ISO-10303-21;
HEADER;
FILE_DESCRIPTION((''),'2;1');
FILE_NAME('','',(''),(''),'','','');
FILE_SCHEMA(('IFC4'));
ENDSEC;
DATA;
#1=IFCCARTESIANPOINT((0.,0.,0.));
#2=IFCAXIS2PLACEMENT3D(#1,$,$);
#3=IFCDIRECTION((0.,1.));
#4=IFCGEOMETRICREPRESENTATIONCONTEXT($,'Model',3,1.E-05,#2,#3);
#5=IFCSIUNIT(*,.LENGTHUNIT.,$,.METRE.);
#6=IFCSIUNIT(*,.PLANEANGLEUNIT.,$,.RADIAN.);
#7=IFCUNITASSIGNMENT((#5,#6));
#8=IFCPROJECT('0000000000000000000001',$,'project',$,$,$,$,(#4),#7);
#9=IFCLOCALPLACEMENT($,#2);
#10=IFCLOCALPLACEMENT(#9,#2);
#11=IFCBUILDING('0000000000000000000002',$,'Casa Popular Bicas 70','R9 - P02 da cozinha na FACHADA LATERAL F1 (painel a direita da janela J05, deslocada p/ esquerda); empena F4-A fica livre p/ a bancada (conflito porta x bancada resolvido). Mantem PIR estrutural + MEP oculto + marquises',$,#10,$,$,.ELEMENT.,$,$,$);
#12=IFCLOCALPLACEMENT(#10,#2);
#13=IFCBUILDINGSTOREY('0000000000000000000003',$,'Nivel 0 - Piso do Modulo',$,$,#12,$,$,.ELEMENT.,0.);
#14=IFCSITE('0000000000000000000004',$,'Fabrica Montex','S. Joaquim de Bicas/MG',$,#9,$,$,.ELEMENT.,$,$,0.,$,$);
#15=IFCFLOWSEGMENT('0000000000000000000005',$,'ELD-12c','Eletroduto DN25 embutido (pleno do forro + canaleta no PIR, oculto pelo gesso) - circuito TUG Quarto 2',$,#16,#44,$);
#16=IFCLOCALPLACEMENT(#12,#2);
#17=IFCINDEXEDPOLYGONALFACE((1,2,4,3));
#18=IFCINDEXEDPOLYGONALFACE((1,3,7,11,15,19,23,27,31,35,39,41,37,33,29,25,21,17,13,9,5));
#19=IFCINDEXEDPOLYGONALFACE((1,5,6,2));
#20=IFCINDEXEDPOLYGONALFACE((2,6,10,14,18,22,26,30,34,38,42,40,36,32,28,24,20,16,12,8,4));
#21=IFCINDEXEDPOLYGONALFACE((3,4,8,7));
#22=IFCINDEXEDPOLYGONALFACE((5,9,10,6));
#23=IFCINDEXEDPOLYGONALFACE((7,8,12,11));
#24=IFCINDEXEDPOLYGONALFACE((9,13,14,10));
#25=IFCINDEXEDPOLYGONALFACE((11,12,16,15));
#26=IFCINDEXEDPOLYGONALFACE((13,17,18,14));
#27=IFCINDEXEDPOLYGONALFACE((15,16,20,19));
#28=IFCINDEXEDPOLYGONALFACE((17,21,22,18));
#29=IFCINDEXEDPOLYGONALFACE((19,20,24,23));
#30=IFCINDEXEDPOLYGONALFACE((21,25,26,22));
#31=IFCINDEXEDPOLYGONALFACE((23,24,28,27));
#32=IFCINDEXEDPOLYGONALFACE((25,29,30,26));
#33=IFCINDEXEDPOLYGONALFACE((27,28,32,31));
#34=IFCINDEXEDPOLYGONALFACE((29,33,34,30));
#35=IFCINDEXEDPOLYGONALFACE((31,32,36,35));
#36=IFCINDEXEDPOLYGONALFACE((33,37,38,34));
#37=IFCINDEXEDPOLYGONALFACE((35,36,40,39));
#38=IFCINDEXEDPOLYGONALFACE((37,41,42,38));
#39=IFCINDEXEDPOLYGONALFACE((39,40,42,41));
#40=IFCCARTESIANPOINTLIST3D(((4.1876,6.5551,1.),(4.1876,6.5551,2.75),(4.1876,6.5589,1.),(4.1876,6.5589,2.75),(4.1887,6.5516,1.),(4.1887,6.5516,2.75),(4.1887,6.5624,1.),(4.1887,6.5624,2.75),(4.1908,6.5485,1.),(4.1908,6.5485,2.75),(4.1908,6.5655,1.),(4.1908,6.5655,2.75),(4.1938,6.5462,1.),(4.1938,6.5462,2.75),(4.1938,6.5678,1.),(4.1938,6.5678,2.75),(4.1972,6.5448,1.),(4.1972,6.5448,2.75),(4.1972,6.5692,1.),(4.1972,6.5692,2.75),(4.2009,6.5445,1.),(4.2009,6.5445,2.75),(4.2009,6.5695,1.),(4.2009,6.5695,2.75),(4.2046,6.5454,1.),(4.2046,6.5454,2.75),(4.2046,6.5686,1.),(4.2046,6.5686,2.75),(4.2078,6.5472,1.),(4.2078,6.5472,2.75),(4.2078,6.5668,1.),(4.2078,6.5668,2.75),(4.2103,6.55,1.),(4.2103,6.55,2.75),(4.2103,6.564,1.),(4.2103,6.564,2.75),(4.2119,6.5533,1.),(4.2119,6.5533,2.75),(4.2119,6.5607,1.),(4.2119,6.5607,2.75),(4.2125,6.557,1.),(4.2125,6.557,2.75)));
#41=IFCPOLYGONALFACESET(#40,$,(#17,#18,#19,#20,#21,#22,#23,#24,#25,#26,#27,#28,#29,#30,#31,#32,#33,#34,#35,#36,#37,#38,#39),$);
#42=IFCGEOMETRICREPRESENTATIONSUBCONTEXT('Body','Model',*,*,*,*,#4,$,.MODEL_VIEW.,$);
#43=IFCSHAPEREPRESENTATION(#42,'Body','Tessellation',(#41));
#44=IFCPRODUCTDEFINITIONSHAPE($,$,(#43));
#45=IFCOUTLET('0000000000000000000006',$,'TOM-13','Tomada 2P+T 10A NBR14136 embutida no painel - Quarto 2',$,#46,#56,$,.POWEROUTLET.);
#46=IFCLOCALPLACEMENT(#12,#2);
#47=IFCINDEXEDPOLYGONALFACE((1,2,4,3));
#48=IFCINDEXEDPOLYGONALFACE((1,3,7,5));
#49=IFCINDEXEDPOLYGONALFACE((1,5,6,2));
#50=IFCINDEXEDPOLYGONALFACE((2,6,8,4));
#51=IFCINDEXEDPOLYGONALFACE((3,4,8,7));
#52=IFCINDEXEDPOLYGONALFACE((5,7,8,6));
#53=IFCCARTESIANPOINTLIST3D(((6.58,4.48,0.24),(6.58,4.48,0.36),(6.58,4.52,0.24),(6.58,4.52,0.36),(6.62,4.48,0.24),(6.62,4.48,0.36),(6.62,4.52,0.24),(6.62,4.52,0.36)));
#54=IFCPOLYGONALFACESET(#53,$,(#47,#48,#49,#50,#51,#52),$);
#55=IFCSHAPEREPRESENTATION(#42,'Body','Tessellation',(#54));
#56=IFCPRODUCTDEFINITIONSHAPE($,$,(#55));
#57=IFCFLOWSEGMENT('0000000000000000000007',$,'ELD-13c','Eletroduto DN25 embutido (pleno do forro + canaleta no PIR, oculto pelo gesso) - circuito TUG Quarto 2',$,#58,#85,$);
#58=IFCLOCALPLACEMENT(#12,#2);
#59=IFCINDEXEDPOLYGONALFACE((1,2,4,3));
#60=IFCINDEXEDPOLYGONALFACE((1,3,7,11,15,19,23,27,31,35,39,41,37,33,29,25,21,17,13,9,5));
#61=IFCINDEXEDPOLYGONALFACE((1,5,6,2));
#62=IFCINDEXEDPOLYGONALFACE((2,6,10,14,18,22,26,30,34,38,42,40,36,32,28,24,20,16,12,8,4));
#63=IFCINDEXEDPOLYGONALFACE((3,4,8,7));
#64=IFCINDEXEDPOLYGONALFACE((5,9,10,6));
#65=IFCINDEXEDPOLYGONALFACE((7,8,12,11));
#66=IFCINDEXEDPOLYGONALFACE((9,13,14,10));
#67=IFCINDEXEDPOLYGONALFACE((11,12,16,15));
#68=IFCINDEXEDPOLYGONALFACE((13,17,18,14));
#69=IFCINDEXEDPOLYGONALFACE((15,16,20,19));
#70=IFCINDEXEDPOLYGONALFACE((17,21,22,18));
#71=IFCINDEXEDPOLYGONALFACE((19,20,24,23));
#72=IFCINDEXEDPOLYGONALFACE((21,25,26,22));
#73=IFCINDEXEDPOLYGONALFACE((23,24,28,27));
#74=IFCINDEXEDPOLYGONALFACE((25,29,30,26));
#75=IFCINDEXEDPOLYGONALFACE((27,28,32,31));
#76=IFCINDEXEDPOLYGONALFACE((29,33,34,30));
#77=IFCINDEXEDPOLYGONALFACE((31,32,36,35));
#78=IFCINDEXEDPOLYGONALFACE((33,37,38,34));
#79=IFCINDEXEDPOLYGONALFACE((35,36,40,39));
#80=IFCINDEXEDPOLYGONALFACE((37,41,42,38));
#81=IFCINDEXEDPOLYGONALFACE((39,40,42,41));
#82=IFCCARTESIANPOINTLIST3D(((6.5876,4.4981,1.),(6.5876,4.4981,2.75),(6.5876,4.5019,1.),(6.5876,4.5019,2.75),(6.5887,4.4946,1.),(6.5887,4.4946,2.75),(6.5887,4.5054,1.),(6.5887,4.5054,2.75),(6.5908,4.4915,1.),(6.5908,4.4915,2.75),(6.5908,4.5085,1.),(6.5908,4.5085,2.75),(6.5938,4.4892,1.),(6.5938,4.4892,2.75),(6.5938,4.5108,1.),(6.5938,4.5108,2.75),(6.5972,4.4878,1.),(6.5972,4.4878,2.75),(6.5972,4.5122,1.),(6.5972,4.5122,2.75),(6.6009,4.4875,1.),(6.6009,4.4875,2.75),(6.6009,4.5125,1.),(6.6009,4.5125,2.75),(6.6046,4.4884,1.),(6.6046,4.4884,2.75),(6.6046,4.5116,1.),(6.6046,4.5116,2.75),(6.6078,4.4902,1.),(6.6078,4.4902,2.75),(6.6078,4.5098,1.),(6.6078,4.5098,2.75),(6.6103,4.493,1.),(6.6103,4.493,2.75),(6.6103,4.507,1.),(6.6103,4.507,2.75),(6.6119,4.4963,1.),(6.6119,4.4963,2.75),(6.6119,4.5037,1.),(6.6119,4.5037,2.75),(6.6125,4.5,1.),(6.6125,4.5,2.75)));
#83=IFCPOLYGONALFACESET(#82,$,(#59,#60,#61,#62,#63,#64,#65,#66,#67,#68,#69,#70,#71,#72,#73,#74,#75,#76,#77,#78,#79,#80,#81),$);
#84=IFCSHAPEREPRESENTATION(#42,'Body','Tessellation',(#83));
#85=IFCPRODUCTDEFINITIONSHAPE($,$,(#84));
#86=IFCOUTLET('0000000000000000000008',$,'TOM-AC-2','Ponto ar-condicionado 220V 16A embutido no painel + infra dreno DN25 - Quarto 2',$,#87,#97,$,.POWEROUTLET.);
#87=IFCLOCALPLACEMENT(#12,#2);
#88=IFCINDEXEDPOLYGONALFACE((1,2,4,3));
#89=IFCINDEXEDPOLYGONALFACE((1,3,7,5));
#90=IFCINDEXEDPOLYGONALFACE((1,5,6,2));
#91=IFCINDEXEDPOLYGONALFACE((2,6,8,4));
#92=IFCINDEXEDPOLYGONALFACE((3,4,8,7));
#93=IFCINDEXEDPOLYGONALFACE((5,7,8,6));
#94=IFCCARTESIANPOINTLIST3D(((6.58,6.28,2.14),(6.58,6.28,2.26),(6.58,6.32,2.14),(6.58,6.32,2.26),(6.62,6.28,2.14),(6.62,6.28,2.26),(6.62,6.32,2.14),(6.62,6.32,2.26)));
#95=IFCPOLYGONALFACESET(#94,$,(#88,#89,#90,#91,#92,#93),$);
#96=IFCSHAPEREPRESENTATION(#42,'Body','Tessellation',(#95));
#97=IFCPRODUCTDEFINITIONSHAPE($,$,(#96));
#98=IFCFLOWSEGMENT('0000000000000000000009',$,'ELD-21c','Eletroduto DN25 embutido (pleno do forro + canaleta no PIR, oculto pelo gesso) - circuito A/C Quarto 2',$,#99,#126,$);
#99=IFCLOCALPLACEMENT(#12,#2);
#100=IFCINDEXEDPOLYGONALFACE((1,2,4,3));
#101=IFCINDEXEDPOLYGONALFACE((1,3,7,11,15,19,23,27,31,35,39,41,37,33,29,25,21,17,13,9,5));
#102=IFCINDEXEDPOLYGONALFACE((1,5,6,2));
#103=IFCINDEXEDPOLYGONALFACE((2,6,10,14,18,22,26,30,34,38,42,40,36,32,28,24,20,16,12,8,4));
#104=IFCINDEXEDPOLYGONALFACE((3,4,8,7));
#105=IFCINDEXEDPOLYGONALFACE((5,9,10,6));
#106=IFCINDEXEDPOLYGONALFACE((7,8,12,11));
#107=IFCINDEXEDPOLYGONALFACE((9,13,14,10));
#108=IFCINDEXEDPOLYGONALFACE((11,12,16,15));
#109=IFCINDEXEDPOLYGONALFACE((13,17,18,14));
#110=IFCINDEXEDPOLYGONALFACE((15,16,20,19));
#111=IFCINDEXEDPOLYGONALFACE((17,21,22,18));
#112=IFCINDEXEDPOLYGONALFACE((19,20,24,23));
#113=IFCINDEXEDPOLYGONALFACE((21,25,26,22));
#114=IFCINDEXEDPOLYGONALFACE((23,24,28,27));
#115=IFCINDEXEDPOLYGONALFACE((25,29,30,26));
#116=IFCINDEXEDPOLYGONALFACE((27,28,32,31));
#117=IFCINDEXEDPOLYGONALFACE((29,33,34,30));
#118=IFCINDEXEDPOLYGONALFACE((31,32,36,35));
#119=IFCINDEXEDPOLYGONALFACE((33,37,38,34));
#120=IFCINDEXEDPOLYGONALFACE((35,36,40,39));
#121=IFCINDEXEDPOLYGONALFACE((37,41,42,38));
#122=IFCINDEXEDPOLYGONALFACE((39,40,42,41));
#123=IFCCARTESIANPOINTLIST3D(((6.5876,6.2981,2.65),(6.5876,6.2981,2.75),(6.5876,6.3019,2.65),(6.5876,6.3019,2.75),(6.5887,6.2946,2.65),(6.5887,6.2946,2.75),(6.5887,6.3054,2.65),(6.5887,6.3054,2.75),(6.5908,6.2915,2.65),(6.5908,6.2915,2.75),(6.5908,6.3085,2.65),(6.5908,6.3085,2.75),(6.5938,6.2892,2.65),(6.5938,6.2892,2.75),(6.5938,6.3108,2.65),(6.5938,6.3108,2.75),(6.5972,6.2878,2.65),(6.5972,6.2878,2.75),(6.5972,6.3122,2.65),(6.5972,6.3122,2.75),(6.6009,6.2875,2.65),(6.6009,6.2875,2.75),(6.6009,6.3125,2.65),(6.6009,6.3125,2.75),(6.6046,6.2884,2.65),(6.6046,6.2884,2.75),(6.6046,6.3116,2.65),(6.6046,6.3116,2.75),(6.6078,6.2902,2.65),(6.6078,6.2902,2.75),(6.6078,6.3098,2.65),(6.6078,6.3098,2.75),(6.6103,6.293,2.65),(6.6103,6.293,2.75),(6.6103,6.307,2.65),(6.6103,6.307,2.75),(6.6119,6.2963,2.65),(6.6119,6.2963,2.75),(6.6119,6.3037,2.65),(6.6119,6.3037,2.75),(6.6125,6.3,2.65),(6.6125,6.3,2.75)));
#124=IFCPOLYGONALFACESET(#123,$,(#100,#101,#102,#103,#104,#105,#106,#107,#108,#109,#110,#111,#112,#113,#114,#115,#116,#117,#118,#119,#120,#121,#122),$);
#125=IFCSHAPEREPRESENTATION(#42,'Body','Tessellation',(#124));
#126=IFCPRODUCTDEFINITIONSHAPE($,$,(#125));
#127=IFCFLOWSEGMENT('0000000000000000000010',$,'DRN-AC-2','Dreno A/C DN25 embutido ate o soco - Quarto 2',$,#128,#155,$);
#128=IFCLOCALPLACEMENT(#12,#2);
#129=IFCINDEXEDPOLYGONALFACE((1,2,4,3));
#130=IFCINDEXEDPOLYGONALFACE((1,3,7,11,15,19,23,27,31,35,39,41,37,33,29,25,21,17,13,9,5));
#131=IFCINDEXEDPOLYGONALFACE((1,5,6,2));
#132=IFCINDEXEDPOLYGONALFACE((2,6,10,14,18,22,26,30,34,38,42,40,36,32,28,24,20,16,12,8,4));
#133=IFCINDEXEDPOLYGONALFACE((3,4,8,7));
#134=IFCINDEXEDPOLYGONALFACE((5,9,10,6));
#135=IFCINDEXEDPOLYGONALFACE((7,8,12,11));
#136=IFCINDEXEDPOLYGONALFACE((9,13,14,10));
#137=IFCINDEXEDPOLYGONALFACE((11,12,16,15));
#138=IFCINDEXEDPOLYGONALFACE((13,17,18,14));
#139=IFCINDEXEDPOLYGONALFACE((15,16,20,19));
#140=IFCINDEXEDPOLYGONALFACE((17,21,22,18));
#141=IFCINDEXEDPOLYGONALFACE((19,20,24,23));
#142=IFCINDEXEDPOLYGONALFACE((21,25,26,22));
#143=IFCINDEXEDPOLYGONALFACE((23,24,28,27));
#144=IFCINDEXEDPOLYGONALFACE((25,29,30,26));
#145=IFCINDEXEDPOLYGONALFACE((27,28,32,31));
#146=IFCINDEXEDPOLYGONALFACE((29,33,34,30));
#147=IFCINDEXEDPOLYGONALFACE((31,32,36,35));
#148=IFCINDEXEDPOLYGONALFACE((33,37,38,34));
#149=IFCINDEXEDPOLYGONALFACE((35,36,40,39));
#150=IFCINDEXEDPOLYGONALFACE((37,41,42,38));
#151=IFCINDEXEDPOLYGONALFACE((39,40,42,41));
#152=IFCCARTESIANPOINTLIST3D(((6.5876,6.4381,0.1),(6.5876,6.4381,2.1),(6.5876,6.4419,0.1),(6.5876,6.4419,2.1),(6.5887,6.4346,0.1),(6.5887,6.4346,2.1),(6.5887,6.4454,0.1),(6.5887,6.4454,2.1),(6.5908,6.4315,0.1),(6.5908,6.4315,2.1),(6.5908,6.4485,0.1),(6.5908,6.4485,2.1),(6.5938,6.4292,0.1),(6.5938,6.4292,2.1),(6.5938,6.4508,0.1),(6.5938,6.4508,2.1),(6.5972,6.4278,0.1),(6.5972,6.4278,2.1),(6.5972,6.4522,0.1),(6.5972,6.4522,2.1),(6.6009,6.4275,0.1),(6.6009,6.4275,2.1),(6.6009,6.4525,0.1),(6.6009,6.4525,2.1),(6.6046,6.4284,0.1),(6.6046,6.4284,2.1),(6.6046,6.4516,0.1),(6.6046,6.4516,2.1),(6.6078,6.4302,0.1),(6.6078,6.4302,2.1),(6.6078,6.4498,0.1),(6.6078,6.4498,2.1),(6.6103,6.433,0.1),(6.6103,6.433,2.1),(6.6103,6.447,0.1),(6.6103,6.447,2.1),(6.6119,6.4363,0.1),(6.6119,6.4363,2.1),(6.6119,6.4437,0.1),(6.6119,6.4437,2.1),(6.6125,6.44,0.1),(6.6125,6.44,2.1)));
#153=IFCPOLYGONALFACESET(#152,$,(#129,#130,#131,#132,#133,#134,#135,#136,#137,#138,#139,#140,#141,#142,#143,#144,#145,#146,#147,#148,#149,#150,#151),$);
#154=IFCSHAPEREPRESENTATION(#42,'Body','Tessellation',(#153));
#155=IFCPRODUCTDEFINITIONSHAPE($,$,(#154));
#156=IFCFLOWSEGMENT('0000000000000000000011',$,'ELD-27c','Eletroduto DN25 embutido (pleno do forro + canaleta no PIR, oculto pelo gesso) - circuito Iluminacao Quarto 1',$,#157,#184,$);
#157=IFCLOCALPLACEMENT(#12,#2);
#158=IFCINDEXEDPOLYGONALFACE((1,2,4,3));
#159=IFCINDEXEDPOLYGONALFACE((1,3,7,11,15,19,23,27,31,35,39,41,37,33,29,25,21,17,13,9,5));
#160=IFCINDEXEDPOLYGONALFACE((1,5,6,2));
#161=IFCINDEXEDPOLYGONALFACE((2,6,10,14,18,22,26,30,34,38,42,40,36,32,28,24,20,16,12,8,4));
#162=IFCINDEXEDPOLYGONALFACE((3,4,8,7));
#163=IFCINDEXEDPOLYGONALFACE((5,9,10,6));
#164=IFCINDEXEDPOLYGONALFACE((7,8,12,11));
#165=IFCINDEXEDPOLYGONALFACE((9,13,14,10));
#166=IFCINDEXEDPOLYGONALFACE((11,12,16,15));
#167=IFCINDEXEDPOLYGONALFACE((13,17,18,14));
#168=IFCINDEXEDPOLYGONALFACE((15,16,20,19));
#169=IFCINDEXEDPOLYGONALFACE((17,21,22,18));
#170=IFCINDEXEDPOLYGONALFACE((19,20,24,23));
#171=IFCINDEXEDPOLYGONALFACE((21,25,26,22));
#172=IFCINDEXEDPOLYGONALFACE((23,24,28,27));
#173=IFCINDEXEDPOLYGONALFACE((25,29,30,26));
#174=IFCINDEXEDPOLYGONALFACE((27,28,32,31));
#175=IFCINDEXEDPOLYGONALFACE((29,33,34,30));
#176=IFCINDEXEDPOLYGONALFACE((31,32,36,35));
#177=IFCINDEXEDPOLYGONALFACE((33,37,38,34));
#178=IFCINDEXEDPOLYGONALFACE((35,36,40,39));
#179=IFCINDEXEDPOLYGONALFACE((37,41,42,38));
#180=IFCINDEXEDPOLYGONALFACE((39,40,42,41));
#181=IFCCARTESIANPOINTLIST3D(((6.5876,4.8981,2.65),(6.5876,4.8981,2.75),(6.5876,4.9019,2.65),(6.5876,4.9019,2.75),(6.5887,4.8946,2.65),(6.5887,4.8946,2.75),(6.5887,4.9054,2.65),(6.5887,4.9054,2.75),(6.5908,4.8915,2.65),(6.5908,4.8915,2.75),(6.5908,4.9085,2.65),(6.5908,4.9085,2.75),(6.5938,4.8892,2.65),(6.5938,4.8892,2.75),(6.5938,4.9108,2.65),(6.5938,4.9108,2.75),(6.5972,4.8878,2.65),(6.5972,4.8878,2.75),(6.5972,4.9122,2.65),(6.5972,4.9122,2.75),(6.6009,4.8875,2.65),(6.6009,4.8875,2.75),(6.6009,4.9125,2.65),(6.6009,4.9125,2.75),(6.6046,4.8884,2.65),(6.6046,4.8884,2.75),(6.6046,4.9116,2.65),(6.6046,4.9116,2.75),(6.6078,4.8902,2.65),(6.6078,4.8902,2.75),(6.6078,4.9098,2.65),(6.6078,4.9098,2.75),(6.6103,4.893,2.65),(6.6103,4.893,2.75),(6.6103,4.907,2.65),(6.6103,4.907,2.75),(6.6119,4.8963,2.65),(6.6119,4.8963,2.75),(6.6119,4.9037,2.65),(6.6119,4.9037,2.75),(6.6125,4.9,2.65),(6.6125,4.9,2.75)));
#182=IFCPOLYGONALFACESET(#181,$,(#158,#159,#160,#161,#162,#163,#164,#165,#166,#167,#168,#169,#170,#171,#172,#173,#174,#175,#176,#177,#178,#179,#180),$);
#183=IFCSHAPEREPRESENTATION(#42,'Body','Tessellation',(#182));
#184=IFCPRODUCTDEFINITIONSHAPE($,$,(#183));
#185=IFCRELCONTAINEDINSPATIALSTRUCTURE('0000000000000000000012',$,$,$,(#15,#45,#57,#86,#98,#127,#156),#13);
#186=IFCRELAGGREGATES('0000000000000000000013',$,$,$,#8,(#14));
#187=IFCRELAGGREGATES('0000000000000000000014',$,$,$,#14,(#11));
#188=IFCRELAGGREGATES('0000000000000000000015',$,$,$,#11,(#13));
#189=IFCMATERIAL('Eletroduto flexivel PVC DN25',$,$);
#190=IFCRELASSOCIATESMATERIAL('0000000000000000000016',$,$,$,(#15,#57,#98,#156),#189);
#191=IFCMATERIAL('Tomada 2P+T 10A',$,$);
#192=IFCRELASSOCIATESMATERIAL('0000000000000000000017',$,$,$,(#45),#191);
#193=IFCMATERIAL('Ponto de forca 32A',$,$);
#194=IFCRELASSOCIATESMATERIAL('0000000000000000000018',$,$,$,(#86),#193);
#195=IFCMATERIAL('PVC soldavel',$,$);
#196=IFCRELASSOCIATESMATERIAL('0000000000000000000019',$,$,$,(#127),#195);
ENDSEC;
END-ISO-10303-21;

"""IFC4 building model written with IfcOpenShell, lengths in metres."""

from ifc_helpers import new_model, si_unit, direction, frame, frame_2d, origin, origin_2d, place, context, subcontext, project, spatial, rectangle, circle, extrude, material, element, save


model = new_model("IFC4")

# Units and contexts
model_context = context("Model", 3, precision=1e-05, world=origin(), true_north=direction((0.0, 1.0)))
body_context = subcontext(model_context, "Body", "Model", "MODEL_VIEW")
ifc_project = project(units=[si_unit("LENGTHUNIT", "METRE"), si_unit("PLANEANGLEUNIT", "RADIAN")], contexts=[model_context])

# Site, building, storey
site_placement = place(None, origin())
site = spatial("IfcSite", under=ifc_project, at=site_placement, Name="Fabrica Montex", Description="S. Joaquim de Bicas/MG", CompositionType="ELEMENT", RefElevation=0.0)
building_placement = place(site_placement, origin())
building = spatial("IfcBuilding", under=site, at=building_placement, Name="Casa Popular Bicas 70", Description="R9 - P02 da cozinha na FACHADA LATERAL F1 (painel a direita da janela J05, deslocada p/ esquerda); empena F4-A fica livre p/ a bancada (conflito porta x bancada resolvido). Mantem PIR estrutural + MEP oculto + marquises", CompositionType="ELEMENT")
storey_placement = place(building_placement, origin())
storey = spatial("IfcBuildingStorey", under=building, at=storey_placement, Name="Nivel 0 - Piso do Modulo", CompositionType="ELEMENT", Elevation=0.0)

# Shared definitions
ifc_material_1 = material(Name="Tomada 2P+T 10A")

# Flow segment
ifc_material_2 = material(Name="Eletroduto flexivel PVC DN25")
flow_segment_1_placement = place(storey_placement, frame((4.2, 6.557, 2.75), z_axis=(0.0, 0.0, -1.0), x_axis=(1.0, 0.0, 0.0)))
element("IfcFlowSegment", 1, at=flow_segment_1_placement, inside=storey, material=ifc_material_2, Name="ELD-12c", Description="Eletroduto DN25 embutido (pleno do forro + canaleta no PIR, oculto pelo gesso) - circuito TUG Quarto 2", context=body_context, shape_type="SweptSolid", body=[
    extrude(circle(Radius=0.0125, at=origin_2d()), origin(), (0.0, 0.0, 1.0), 1.75),
])

# Outlet
outlet_1_placement = place(storey_placement, frame((6.58, 4.48, 0.24)))
element("IfcOutlet", 2, at=outlet_1_placement, inside=storey, material=ifc_material_1, Name="TOM-13", Description="Tomada 2P+T 10A NBR14136 embutida no painel - Quarto 2", PredefinedType="POWEROUTLET", context=body_context, shape_type="SweptSolid", body=[
    extrude(rectangle(XDim=0.04, YDim=0.04, at=frame_2d((0.02, 0.02))), origin(), (0.0, 0.0, 1.0), 0.12),
])

# Flow segment
flow_segment_2_placement = place(storey_placement, frame((6.6, 4.5, 2.75), z_axis=(0.0, 0.0, -1.0), x_axis=(1.0, 0.0, 0.0)))
element("IfcFlowSegment", 3, at=flow_segment_2_placement, inside=storey, material=ifc_material_2, Name="ELD-13c", Description="Eletroduto DN25 embutido (pleno do forro + canaleta no PIR, oculto pelo gesso) - circuito TUG Quarto 2", context=body_context, shape_type="SweptSolid", body=[
    extrude(circle(Radius=0.0125, at=origin_2d()), origin(), (0.0, 0.0, 1.0), 1.75),
])

# Outlet
ifc_material_3 = material(Name="Ponto de forca 32A")
outlet_2_placement = place(storey_placement, frame((6.58, 6.28, 2.14)))
element("IfcOutlet", 4, at=outlet_2_placement, inside=storey, material=ifc_material_3, Name="TOM-AC-2", Description="Ponto ar-condicionado 220V 16A embutido no painel + infra dreno DN25 - Quarto 2", PredefinedType="POWEROUTLET", context=body_context, shape_type="SweptSolid", body=[
    extrude(rectangle(XDim=0.04, YDim=0.04, at=frame_2d((0.02, 0.02))), origin(), (0.0, 0.0, 1.0), 0.12),
])

# Flow segments
flow_segment_3_placement = place(storey_placement, frame((6.6, 6.3, 2.75), z_axis=(0.0, 0.0, -1.0), x_axis=(1.0, 0.0, 0.0)))
element("IfcFlowSegment", 5, at=flow_segment_3_placement, inside=storey, material=ifc_material_2, Name="ELD-21c", Description="Eletroduto DN25 embutido (pleno do forro + canaleta no PIR, oculto pelo gesso) - circuito A/C Quarto 2", context=body_context, shape_type="SweptSolid", body=[
    extrude(circle(Radius=0.0125, at=origin_2d()), origin(), (0.0, 0.0, 1.0), 0.1),
])
ifc_material_4 = material(Name="PVC soldavel")
flow_segment_4_placement = place(storey_placement, frame((6.6, 6.44, 2.1), z_axis=(0.0, 0.0, -1.0), x_axis=(1.0, 0.0, 0.0)))
element("IfcFlowSegment", 6, at=flow_segment_4_placement, inside=storey, material=ifc_material_4, Name="DRN-AC-2", Description="Dreno A/C DN25 embutido ate o soco - Quarto 2", context=body_context, shape_type="SweptSolid", body=[
    extrude(circle(Radius=0.0125, at=origin_2d()), origin(), (0.0, 0.0, 1.0), 2.0),
])
flow_segment_5_placement = place(storey_placement, frame((6.6, 4.9, 2.75), z_axis=(0.0, 0.0, -1.0), x_axis=(1.0, 0.0, 0.0)))
element("IfcFlowSegment", 7, at=flow_segment_5_placement, inside=storey, material=ifc_material_2, Name="ELD-27c", Description="Eletroduto DN25 embutido (pleno do forro + canaleta no PIR, oculto pelo gesso) - circuito Iluminacao Quarto 1", context=body_context, shape_type="SweptSolid", body=[
    extrude(circle(Radius=0.0125, at=origin_2d()), origin(), (0.0, 0.0, 1.0), 0.1),
])

save(model, "model.ifc")
